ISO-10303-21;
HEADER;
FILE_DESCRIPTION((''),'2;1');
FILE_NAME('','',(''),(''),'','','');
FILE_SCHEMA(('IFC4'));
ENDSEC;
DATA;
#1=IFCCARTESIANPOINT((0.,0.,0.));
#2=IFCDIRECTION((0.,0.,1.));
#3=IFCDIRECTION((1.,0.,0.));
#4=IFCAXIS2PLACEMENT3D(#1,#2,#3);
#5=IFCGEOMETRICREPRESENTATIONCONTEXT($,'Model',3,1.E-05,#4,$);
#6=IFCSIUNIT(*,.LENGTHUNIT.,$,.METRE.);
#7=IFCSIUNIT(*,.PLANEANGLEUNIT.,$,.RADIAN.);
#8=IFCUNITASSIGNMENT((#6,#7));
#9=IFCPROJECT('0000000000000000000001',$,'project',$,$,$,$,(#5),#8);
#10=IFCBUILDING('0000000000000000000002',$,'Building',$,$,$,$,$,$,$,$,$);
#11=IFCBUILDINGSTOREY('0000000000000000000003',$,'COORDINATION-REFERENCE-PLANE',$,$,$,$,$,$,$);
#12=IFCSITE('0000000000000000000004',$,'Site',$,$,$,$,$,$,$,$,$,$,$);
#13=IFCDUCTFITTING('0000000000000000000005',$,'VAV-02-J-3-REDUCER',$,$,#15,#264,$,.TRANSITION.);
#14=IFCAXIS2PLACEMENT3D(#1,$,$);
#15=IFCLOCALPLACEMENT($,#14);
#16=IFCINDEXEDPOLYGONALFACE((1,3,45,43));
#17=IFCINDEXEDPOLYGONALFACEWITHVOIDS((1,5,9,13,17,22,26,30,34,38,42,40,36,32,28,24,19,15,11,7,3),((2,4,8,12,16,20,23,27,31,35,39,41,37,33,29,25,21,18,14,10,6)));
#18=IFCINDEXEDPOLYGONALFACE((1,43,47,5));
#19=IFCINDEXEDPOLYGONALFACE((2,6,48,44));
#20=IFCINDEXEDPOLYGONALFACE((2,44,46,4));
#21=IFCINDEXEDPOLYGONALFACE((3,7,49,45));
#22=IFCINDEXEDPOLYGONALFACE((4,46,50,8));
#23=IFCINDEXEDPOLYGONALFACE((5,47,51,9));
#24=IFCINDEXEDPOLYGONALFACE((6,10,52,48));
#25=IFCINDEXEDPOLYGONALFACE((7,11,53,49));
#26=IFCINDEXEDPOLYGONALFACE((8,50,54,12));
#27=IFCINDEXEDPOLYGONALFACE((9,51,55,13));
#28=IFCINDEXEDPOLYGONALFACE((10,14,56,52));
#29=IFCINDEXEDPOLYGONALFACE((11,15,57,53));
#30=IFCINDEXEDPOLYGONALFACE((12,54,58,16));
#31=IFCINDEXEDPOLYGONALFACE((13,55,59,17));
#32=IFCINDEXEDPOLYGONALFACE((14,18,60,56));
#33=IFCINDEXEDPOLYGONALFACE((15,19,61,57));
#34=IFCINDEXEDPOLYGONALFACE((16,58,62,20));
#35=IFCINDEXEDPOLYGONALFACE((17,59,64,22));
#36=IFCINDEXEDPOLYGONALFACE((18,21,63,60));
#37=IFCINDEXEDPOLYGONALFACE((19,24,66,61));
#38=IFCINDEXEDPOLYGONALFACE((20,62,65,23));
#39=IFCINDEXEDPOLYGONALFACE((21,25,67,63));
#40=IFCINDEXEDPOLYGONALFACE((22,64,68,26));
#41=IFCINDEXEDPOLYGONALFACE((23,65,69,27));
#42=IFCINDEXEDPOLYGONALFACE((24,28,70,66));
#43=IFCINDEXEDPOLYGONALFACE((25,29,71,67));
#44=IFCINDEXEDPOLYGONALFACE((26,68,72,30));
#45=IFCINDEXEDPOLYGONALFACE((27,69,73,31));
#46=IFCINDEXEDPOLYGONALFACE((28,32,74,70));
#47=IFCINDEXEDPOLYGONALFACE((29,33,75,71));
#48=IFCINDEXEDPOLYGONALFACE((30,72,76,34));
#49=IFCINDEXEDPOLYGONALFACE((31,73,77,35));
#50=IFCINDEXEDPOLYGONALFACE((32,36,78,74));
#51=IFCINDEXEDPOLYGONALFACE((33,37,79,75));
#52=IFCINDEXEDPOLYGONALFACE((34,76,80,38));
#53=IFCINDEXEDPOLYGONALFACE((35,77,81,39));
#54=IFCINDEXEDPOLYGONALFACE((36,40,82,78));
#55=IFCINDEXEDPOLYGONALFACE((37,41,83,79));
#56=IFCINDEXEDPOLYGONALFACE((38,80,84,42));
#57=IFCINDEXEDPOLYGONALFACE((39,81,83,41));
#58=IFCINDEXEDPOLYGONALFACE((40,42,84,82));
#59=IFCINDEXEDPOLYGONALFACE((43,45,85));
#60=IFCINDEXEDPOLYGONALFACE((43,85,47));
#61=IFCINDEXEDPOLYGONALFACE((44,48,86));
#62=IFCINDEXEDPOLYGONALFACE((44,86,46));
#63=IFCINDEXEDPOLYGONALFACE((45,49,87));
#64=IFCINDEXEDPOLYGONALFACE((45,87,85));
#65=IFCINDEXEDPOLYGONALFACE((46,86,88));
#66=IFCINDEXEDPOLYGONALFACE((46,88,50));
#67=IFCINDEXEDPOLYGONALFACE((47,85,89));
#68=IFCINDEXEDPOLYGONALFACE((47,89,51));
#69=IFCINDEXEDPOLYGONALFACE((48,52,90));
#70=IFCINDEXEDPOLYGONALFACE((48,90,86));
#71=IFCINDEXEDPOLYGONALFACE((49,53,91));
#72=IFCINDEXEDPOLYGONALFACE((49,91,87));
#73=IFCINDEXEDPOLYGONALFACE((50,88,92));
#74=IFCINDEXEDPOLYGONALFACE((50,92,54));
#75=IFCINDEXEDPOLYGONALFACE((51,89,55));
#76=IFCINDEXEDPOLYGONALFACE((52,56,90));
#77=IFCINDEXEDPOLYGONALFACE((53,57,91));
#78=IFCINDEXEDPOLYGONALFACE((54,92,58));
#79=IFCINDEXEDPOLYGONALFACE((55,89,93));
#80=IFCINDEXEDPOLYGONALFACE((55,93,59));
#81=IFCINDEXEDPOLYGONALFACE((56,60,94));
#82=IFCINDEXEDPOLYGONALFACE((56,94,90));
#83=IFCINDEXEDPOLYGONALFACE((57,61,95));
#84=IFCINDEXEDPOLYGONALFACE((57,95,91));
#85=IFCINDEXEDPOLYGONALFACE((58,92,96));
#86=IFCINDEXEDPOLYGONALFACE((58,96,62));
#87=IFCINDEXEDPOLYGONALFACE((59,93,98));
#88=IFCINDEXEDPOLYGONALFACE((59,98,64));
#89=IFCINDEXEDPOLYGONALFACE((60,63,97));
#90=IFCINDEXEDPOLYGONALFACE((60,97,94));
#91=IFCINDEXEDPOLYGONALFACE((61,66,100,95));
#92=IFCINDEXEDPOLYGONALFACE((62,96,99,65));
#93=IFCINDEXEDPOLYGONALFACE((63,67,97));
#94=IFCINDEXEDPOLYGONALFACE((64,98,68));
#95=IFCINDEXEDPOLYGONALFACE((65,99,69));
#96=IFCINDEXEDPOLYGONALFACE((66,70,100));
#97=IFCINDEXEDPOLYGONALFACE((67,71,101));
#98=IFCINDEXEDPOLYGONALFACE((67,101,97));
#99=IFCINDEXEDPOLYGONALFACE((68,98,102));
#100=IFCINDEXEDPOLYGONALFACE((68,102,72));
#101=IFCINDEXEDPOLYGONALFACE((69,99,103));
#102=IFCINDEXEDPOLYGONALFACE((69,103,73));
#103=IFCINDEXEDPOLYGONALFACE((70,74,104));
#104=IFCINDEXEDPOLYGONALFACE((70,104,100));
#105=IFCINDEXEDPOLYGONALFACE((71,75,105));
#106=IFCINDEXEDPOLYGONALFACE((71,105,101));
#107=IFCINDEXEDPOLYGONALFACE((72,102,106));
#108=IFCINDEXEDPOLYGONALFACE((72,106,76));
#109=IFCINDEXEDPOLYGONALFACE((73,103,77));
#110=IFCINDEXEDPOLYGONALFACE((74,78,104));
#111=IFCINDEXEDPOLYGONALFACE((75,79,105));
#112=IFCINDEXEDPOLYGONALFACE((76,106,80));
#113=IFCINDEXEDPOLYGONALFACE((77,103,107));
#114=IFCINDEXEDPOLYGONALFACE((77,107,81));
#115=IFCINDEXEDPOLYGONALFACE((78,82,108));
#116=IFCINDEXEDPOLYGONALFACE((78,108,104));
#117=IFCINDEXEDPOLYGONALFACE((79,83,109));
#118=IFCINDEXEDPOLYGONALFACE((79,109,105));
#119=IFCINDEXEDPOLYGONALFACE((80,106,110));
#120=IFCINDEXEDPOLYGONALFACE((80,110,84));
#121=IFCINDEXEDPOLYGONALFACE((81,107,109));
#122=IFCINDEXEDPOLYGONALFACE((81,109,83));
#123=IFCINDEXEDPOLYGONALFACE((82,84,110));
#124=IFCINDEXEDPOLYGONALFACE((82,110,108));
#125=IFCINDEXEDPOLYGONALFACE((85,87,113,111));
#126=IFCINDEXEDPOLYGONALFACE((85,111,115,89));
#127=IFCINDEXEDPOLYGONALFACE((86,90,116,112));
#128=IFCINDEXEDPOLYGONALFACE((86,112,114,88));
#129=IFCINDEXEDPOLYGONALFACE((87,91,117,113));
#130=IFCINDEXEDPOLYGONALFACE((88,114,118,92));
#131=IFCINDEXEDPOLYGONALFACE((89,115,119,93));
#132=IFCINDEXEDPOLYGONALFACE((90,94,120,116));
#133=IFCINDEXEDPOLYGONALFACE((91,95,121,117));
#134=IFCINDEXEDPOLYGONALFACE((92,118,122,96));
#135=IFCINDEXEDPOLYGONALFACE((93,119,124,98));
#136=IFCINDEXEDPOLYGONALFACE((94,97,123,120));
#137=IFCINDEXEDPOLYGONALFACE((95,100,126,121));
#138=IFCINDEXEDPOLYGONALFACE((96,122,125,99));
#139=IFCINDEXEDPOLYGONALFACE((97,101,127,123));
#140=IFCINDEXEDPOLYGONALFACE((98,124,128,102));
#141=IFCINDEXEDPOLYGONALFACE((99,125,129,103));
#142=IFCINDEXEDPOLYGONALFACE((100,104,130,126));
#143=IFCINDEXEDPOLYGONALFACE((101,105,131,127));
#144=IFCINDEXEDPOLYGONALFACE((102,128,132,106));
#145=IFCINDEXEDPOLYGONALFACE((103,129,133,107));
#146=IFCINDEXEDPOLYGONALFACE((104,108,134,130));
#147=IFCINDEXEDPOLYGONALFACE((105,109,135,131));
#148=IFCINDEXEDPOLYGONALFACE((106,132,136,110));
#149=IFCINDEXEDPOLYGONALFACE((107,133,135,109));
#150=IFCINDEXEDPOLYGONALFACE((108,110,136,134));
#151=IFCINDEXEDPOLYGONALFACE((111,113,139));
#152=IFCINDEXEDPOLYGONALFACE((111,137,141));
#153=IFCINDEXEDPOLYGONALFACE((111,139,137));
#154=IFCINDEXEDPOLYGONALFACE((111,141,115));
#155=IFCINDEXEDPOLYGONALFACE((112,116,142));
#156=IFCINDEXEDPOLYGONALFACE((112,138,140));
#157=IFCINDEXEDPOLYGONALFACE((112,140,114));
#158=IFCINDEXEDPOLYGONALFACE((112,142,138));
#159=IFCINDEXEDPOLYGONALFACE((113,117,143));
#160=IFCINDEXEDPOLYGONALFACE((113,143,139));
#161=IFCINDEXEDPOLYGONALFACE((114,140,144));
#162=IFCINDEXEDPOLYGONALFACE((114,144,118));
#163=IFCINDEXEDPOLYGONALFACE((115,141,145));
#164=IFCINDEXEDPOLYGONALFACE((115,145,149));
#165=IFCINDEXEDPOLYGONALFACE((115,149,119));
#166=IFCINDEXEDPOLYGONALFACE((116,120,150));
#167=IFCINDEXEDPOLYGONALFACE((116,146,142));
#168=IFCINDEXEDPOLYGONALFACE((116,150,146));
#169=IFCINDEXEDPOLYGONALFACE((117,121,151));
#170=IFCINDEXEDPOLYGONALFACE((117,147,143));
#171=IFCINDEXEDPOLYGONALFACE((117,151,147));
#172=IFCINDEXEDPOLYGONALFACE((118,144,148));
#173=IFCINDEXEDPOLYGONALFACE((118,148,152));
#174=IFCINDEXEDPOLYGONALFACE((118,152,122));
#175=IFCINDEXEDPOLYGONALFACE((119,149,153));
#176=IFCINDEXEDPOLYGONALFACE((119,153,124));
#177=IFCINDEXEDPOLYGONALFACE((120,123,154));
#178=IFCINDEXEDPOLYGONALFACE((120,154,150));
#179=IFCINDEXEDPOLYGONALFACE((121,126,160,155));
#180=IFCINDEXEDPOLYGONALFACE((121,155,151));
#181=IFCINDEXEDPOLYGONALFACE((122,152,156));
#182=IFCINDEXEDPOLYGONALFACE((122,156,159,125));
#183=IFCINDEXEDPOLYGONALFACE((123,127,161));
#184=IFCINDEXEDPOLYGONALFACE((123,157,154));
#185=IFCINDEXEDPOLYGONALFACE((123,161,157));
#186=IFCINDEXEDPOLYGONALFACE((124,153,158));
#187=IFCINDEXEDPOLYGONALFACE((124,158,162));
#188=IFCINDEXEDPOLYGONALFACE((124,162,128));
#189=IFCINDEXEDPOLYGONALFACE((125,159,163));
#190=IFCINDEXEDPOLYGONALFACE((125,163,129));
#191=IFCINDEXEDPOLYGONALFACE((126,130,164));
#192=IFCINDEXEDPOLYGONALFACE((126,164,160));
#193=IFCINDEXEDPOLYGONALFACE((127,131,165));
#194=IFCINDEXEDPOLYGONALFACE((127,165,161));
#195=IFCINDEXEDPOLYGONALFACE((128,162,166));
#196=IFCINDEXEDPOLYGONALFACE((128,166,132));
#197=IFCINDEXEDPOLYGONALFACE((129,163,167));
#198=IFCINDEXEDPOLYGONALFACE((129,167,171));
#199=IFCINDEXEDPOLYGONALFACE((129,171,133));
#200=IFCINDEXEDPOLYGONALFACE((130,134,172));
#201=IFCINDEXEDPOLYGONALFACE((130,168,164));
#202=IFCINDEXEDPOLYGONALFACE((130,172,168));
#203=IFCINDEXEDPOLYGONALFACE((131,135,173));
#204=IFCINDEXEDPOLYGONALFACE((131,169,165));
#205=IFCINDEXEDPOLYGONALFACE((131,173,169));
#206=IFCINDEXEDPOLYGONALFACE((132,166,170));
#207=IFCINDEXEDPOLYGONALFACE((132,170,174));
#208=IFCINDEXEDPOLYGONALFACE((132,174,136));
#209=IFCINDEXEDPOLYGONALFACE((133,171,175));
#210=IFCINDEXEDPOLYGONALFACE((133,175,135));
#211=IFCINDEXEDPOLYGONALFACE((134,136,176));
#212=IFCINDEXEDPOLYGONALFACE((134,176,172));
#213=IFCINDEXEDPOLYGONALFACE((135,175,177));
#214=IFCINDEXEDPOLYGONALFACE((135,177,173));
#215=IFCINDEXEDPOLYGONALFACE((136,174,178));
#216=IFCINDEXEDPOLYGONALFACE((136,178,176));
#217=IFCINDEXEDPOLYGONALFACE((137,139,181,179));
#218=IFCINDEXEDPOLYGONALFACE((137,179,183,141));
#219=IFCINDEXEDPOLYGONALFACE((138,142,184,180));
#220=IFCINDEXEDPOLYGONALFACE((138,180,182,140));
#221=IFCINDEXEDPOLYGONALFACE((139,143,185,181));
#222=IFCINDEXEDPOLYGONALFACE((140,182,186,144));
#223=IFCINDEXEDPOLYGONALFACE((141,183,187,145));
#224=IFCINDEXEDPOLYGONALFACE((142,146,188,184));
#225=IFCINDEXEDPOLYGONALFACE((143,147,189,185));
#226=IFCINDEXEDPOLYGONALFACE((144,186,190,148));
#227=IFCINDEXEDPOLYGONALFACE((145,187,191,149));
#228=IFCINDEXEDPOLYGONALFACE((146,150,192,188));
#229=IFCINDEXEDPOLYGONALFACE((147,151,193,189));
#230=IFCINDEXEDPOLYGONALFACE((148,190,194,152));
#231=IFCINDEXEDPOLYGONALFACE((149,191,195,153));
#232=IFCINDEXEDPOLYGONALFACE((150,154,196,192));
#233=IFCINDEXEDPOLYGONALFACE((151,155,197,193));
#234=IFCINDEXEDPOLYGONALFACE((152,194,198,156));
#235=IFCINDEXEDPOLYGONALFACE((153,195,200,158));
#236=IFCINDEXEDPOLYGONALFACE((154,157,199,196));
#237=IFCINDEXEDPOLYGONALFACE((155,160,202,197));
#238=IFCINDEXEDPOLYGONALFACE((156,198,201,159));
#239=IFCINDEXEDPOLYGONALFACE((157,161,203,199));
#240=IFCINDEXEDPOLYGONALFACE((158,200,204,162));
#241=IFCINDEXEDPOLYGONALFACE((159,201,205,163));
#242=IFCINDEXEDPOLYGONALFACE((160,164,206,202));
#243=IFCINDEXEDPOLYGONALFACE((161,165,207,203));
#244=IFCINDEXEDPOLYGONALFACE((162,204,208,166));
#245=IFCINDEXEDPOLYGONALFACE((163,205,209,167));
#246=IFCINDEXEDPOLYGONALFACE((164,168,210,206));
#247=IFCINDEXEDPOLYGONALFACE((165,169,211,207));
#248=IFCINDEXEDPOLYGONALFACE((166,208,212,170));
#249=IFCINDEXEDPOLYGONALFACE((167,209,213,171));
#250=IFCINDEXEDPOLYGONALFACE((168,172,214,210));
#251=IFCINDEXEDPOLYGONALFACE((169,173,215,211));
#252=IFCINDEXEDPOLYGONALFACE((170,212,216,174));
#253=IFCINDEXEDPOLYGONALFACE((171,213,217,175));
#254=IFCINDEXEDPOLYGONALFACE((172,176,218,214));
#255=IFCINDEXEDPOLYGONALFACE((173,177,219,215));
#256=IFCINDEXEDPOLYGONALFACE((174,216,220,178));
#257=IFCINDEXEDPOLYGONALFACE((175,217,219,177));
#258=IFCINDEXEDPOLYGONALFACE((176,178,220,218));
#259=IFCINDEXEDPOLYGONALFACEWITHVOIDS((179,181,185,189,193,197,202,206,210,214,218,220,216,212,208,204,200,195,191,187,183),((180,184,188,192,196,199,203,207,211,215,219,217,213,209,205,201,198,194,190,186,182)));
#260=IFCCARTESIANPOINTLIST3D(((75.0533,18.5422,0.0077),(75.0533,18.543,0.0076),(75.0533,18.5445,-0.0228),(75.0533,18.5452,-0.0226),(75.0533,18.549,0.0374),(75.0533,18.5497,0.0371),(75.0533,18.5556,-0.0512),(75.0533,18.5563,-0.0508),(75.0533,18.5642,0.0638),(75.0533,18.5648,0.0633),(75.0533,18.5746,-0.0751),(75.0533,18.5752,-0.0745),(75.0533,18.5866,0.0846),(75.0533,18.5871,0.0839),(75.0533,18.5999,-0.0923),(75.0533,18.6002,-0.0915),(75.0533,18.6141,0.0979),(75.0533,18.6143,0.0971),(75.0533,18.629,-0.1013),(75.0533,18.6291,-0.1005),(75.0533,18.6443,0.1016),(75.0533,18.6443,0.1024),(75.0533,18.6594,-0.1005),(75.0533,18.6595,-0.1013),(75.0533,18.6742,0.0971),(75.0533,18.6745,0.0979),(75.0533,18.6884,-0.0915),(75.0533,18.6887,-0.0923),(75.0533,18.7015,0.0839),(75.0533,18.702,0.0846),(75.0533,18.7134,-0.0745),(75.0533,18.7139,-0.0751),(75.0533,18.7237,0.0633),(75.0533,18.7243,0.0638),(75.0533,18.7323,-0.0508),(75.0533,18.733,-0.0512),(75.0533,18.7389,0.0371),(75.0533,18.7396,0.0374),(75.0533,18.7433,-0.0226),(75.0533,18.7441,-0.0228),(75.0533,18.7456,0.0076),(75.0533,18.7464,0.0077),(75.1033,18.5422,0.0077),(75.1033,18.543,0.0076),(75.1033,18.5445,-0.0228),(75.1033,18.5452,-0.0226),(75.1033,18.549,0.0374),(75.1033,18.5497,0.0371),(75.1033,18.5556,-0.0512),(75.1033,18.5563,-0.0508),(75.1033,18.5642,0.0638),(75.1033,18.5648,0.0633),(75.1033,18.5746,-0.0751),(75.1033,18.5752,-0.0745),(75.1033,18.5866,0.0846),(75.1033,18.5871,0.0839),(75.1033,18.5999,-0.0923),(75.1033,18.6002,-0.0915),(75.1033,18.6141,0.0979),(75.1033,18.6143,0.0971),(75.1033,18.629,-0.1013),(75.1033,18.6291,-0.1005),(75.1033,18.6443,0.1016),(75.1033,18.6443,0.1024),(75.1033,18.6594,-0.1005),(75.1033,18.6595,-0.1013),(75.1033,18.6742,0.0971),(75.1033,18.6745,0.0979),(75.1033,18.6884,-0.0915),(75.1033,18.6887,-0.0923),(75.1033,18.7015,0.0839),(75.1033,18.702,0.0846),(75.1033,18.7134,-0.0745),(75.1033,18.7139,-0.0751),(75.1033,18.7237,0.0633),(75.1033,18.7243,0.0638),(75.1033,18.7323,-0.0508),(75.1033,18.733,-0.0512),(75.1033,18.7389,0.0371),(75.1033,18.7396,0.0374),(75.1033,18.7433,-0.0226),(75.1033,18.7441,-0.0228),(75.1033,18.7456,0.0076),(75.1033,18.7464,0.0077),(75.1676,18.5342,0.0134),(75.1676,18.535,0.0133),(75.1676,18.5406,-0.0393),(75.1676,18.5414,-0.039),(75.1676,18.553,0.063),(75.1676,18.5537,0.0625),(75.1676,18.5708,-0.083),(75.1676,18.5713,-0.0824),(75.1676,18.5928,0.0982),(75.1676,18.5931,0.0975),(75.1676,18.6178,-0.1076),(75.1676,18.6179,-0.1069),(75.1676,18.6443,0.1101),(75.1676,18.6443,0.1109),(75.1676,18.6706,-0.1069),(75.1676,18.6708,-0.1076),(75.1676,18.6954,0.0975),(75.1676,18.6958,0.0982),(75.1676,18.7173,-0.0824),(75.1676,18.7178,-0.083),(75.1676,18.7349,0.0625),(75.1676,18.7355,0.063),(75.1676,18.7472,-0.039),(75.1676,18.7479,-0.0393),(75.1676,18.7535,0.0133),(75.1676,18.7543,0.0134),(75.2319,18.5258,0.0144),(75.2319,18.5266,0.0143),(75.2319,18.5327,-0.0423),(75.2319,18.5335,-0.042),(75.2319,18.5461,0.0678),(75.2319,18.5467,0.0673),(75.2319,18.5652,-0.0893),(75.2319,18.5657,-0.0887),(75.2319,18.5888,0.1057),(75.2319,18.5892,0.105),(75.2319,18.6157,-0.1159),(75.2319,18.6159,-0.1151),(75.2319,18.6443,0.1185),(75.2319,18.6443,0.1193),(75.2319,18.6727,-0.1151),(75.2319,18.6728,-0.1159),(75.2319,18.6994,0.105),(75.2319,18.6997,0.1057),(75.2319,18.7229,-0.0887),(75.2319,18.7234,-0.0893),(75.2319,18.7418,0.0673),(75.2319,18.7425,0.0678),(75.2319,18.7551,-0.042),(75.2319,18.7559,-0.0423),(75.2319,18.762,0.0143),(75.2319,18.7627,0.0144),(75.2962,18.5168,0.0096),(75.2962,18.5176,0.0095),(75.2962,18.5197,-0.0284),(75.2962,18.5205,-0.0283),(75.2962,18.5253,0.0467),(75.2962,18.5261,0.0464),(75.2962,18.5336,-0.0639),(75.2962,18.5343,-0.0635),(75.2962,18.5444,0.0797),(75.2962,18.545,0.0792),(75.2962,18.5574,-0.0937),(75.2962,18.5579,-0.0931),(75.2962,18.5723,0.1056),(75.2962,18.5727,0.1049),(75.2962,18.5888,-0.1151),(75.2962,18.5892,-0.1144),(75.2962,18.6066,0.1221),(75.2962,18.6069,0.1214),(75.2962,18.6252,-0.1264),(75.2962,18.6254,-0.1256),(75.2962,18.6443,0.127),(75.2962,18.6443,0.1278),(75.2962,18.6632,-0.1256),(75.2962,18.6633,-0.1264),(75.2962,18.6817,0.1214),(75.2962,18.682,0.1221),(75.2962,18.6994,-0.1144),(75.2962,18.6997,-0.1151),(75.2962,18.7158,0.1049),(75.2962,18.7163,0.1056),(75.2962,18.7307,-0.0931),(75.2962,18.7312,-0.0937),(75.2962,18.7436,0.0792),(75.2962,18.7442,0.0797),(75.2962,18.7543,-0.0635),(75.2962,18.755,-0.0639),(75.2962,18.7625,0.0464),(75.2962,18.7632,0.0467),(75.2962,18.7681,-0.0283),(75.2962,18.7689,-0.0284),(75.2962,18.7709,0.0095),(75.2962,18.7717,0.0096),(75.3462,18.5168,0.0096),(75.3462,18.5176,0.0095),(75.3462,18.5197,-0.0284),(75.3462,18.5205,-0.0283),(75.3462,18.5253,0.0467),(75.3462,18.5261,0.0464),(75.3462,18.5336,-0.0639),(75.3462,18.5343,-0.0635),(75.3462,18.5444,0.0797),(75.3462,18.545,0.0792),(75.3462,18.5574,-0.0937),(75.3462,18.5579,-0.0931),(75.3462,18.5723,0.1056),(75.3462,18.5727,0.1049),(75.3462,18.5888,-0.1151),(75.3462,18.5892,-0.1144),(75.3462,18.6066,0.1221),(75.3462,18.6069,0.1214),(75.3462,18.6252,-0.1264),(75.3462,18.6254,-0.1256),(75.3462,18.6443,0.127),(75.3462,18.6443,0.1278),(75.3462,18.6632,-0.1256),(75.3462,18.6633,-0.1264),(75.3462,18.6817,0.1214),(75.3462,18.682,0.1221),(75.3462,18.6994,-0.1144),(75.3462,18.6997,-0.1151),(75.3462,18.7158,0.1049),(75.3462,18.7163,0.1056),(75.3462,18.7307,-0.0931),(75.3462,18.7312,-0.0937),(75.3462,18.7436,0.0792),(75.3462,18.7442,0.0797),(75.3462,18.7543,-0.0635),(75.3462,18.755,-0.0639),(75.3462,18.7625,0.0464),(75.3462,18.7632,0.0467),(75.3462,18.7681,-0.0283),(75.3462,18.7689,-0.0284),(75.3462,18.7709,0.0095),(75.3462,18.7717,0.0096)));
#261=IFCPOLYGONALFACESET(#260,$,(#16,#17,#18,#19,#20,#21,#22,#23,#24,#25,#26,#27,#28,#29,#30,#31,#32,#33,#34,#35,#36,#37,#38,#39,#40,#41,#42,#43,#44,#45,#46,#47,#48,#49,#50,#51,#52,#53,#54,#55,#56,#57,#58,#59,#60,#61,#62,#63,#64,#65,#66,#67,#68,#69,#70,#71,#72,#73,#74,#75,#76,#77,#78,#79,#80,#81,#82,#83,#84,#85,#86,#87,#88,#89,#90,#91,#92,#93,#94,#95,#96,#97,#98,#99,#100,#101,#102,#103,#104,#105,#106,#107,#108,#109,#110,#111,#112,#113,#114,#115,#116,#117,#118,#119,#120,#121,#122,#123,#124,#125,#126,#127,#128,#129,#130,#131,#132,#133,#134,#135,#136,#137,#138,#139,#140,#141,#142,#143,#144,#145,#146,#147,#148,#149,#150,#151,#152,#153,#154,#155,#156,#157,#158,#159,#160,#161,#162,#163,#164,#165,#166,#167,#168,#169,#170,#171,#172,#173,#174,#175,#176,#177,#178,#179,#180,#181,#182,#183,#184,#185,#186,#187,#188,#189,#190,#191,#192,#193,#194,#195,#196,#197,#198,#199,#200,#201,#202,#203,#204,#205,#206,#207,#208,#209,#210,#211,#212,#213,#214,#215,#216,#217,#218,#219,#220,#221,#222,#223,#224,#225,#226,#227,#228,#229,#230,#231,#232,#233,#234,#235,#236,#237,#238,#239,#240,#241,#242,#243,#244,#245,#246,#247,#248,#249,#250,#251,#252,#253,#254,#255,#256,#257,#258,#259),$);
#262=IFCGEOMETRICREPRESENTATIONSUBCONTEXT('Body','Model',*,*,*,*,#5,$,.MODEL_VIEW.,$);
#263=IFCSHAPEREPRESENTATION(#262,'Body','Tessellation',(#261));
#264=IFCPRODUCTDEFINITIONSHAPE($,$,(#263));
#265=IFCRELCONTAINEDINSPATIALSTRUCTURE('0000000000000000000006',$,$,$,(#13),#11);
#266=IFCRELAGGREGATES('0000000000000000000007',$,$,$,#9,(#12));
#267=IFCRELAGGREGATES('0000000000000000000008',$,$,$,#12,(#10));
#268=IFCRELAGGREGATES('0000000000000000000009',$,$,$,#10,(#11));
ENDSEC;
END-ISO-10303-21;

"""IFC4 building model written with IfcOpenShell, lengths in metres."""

from ifc_helpers import new_model, entity, si_unit, frame, origin_with_axes, place, context, subcontext, project, spatial, element, save


model = new_model("IFC4")

# Units and contexts
model_context = context("Model", 3, precision=1e-05, world=origin_with_axes())
body_context_1 = subcontext(model_context, "Body", "Model", "MODEL_VIEW")
ifc_project = project(units=[si_unit("LENGTHUNIT", "METRE"), si_unit("PLANEANGLEUNIT", "RADIAN")], contexts=[model_context])

# Site, building, storey
site = spatial("IfcSite", under=ifc_project, Name="Site")
building = spatial("IfcBuilding", under=site, Name="Building")
storey = spatial("IfcBuildingStorey", under=building, Name="COORDINATION-REFERENCE-PLANE")

# Duct fitting
for number, where, z_axis, x_axis, name in (
    (1, (75.3462, 18.6443, 0.0), (0.0, -1.0, 0.0), (0.0, 0.0, 1.0), "VAV-02-J-3-REDUCER"),
):
    element("IfcDuctFitting", number, at=place(None, frame(where, z_axis=z_axis, x_axis=x_axis)), inside=storey, Name=name, PredefinedType="TRANSITION", context=body_context_1, shape_type="SweptSolid", body=[
        entity("IfcRevolvedAreaSolid", entity("IfcArbitraryClosedProfileDef", "AREA", None, entity("IfcPolyline", [entity("IfcCartesianPoint", [0.1278, 0.0]), entity("IfcCartesianPoint", [0.1278, 0.05]), entity("IfcCartesianPoint", [0.1024, 0.2429]), entity("IfcCartesianPoint", [0.1024, 0.2929]), entity("IfcCartesianPoint", [0.1016, 0.2929]), entity("IfcCartesianPoint", [0.1016, 0.2429]), entity("IfcCartesianPoint", [0.127, 0.05]), entity("IfcCartesianPoint", [0.127, 0.0]), entity("IfcCartesianPoint", [0.1278, 0.0])])), entity("IfcAxis2Placement3D", entity("IfcCartesianPoint", [0.0, 0.0, 0.0])), entity("IfcAxis1Placement", entity("IfcCartesianPoint", [0.0, 0.0, 0.0]), entity("IfcDirection", [0.0, 1.0, 0.0])), 6.283185),
    ])

save(model, "model.ifc")
